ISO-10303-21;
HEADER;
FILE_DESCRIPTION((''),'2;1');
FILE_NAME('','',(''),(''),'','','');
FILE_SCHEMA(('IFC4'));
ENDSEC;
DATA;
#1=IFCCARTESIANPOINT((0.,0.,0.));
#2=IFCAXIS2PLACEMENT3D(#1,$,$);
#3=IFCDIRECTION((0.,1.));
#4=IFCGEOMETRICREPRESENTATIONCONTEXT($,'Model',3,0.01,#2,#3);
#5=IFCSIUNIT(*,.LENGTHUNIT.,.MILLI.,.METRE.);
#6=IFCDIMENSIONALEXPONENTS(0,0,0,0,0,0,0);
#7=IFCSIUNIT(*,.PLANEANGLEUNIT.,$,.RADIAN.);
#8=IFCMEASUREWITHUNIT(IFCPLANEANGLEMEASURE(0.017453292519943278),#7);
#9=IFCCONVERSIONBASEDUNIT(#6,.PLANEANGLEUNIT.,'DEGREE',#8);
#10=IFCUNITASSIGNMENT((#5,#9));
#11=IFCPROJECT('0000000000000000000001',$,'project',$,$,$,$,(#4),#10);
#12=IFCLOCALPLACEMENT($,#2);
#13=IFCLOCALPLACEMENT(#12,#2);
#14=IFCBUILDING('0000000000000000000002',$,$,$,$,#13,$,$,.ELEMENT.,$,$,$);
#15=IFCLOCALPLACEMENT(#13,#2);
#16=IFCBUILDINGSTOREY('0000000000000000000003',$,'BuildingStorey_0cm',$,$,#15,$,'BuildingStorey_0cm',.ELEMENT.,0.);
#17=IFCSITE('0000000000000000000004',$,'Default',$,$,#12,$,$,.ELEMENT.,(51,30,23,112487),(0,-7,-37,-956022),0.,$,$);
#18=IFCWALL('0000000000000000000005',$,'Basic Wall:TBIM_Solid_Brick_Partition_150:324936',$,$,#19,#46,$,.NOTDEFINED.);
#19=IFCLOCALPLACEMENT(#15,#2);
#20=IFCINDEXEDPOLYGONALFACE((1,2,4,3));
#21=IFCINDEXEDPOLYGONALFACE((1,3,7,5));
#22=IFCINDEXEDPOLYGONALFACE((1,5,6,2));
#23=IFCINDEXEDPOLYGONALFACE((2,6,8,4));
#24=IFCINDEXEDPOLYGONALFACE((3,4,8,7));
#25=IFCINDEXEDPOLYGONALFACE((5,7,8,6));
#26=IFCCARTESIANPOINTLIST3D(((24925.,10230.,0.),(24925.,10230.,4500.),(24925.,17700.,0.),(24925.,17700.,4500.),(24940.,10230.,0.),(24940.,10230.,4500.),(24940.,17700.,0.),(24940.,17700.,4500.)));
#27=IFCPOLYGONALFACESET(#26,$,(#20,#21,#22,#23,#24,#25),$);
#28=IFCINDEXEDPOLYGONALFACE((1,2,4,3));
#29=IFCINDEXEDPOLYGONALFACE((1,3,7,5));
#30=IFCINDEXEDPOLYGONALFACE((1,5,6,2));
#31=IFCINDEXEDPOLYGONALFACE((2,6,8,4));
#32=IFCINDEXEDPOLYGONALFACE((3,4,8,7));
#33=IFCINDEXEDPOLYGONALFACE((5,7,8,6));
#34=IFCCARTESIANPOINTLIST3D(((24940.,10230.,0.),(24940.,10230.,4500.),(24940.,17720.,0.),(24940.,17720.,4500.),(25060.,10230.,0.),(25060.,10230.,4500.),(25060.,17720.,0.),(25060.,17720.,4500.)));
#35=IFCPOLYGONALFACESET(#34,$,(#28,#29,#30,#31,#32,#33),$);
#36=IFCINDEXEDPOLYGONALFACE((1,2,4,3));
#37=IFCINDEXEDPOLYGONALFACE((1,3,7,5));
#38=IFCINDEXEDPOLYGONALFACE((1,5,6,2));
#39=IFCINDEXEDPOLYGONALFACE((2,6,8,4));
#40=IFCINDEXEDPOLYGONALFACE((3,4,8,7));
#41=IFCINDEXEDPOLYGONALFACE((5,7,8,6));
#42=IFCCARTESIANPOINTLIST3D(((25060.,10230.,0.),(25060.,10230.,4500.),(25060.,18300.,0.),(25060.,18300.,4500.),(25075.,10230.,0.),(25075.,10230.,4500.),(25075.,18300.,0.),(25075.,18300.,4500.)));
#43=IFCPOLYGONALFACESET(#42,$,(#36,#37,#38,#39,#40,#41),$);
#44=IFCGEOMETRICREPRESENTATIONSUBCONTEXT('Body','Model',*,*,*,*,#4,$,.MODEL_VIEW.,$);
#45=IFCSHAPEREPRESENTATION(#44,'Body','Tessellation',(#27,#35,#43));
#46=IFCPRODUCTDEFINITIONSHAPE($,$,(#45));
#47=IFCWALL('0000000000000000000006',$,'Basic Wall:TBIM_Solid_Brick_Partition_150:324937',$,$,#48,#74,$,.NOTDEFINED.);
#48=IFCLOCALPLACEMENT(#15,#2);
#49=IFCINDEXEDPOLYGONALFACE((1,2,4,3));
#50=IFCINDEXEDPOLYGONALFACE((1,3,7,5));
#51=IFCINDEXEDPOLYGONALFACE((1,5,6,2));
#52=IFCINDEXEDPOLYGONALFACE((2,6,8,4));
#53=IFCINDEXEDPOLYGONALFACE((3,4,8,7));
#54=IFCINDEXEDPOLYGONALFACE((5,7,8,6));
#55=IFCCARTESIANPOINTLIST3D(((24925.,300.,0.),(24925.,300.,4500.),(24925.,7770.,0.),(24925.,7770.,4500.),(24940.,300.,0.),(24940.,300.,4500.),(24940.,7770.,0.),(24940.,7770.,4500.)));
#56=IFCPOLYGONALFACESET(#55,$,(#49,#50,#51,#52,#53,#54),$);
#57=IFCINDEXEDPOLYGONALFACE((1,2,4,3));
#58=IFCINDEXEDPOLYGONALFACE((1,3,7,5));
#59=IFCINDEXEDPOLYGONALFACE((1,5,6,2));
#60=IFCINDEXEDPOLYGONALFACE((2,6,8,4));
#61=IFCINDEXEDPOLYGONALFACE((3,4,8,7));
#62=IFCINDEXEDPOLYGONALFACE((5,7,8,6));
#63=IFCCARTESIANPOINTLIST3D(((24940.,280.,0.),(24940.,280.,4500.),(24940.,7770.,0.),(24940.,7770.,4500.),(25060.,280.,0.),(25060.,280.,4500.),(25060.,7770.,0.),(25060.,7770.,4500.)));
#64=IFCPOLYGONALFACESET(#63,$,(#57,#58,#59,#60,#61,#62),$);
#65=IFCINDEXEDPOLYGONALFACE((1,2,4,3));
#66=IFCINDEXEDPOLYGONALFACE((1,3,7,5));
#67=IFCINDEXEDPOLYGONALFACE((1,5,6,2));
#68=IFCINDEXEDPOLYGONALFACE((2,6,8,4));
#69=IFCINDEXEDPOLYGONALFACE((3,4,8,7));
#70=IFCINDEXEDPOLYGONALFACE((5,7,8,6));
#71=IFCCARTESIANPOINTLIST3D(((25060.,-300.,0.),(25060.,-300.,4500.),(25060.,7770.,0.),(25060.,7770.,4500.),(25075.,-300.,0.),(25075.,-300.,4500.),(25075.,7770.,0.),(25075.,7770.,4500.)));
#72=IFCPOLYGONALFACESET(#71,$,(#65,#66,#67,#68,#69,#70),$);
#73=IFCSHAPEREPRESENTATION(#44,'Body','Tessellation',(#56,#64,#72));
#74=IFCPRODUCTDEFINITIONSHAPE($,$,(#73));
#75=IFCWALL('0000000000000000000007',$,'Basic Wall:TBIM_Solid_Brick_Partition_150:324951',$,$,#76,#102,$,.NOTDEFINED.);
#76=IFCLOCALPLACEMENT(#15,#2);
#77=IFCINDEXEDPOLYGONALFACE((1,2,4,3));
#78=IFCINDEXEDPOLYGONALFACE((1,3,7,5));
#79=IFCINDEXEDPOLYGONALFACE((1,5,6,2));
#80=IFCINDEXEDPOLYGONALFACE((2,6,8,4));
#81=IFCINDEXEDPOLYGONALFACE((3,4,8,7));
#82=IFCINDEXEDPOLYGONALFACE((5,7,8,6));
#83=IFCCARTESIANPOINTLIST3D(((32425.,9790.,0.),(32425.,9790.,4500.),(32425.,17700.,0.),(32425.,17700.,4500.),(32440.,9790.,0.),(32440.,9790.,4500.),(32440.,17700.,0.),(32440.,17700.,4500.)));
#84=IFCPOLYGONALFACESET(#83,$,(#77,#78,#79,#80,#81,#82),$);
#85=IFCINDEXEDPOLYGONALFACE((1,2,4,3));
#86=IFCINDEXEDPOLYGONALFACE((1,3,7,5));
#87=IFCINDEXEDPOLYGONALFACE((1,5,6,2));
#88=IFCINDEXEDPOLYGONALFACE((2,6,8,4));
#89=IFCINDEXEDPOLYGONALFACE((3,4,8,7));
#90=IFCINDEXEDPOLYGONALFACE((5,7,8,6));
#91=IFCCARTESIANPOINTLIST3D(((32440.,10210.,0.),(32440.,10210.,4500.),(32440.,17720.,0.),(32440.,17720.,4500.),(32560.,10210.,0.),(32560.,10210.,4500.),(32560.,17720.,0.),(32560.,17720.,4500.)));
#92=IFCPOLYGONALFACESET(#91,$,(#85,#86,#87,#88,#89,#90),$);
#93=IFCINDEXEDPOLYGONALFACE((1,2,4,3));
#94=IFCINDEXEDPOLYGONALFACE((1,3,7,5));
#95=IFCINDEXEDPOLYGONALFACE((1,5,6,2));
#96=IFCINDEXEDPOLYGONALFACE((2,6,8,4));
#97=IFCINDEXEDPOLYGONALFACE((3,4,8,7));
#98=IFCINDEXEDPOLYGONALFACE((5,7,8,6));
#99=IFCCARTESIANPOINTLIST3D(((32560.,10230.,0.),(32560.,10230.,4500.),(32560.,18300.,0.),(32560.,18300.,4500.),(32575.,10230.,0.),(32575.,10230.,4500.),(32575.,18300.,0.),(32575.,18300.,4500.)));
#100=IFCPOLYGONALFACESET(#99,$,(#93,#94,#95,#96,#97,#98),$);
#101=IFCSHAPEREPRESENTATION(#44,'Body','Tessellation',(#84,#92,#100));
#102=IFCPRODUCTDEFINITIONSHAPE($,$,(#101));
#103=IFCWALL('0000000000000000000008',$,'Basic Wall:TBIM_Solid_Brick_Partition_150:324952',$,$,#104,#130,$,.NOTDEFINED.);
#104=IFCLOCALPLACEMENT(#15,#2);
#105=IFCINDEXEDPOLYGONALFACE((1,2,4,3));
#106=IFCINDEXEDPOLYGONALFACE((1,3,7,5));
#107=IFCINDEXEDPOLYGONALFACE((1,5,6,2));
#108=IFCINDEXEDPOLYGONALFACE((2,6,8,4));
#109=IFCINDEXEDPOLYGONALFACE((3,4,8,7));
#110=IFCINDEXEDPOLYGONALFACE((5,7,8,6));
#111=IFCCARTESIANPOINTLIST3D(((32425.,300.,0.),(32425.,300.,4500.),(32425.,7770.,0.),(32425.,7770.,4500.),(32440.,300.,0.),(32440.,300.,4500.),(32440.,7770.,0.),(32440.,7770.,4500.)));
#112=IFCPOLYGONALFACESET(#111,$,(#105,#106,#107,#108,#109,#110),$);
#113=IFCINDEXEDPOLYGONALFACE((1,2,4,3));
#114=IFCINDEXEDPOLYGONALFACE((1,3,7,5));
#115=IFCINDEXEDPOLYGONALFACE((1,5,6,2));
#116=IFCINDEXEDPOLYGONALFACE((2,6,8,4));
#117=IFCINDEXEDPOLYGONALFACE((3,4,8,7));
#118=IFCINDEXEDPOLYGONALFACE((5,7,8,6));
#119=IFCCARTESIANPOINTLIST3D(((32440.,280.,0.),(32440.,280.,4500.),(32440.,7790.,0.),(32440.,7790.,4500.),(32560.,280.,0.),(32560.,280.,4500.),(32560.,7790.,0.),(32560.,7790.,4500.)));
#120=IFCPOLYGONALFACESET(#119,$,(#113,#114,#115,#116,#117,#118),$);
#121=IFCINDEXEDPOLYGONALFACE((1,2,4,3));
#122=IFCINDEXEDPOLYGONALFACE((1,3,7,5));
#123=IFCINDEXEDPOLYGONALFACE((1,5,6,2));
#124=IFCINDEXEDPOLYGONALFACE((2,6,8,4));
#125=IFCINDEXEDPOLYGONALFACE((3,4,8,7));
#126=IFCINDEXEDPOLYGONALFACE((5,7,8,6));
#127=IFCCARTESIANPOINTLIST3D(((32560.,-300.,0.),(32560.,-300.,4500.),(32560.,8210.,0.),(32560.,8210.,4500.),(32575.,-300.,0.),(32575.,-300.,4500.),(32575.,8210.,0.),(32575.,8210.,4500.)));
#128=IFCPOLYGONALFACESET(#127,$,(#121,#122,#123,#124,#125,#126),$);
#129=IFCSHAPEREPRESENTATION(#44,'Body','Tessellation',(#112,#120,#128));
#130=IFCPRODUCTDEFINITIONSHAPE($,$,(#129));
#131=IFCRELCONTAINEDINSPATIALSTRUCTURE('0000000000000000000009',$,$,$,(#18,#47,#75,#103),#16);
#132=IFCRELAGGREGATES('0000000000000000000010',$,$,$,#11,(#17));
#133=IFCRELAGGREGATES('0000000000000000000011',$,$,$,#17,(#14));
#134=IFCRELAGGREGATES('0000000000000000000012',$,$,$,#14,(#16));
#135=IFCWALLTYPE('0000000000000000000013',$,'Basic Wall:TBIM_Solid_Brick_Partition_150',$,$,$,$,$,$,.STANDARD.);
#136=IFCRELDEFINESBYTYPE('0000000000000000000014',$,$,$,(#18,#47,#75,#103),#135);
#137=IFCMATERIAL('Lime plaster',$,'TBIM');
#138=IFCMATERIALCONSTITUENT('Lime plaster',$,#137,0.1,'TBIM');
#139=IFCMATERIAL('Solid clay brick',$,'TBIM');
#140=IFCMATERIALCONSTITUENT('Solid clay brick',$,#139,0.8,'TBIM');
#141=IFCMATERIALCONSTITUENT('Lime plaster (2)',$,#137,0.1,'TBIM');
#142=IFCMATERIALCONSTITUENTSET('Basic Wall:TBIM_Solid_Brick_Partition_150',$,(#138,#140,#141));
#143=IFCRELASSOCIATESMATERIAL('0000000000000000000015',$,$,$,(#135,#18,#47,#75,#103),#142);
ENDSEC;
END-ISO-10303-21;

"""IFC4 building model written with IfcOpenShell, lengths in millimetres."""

from ifc_helpers import new_model, entity, si_unit, converted_unit, direction, frame, origin, place, context, subcontext, project, spatial, indexed_curve, outline, extrude, material, constituent, constituent_set, type_object, element, save


model = new_model("IFC4")

# Units and contexts
model_context = context("Model", 3, precision=0.01, world=origin(), true_north=direction((0.0, 1.0)))
body_context = subcontext(model_context, "Body", "Model", "MODEL_VIEW")
ifc_project = project(units=[si_unit("LENGTHUNIT", "METRE", prefix="MILLI"), converted_unit("PLANEANGLEUNIT", "DEGREE", entity("IfcPlaneAngleMeasure", 0.017453292519943278), si_unit("PLANEANGLEUNIT", "RADIAN"), dimensions=[0, 0, 0, 0, 0, 0, 0])], contexts=[model_context])

# Site, building, storey
site_placement = place(None, origin())
site = spatial("IfcSite", under=ifc_project, at=site_placement, Name="Default", CompositionType="ELEMENT", RefLatitude=(51, 30, 23, 112487), RefLongitude=(0, -7, -37, -956022), RefElevation=0.0)
building_placement = place(site_placement, origin())
building = spatial("IfcBuilding", under=site, at=building_placement, CompositionType="ELEMENT")
storey_placement = place(building_placement, origin())
storey = spatial("IfcBuildingStorey", under=building, at=storey_placement, Name="BuildingStorey_0cm", LongName="BuildingStorey_0cm", CompositionType="ELEMENT", Elevation=0.0)

# Shared definitions
ifc_material_1 = material(Name="Solid clay brick", Category="TBIM")
ifc_material_2 = material(Name="Lime plaster", Category="TBIM")

# Walls
ifc_constituent_1 = constituent(ifc_material_2, Name="Lime plaster", Category="TBIM", fraction=0.1)
ifc_constituent_2 = constituent(ifc_material_1, Name="Solid clay brick", Category="TBIM", fraction=0.8)
ifc_constituent_3 = constituent(ifc_material_2, Name="Lime plaster (2)", Category="TBIM", fraction=0.1)
ifc_constituent_set_1 = constituent_set(constituents=[ifc_constituent_1, ifc_constituent_2, ifc_constituent_3], Name="Basic Wall:TBIM_Solid_Brick_Partition_150")
wall_type_1 = type_object("IfcWallType", Name="Basic Wall:TBIM_Solid_Brick_Partition_150", PredefinedType="STANDARD", material=ifc_constituent_set_1)
wall_1_placement = place(storey_placement, frame((25000.0, 10230.0, 0.0), z_axis=(0.0, 0.0, 1.0), x_axis=(0.0, 1.0, 0.0)))
element("IfcWall", 1, at=wall_1_placement, inside=storey, type_object=wall_type_1, material=ifc_constituent_set_1, Name="Basic Wall:TBIM_Solid_Brick_Partition_150:324936", PredefinedType="NOTDEFINED", context=body_context, shape_type="SweptSolid", body=[
    extrude(outline(indexed_curve([(-7.5, -3735.0), (7.5, -3735.0), (7.5, 3735.0), (-7.5, 3735.0), (-7.5, -3735.0)], self_intersect=False)), frame((3735.0, 67.5, 0.0), z_axis=(0.0, 0.0, 1.0), x_axis=(0.0, -1.0, 0.0)), (0.0, 0.0, 1.0), 4500.0),
    extrude(outline(indexed_curve([(-3745.0, -60.0), (3745.0, -60.0), (3745.0, 60.0), (-3745.0, 60.0), (-3745.0, -60.0)], self_intersect=False)), frame((3745.0, 0.0, 0.0)), (0.0, 0.0, 1.0), 4500.0),
    extrude(outline(indexed_curve([(-7.5, -4035.0), (7.5, -4035.0), (7.5, 4035.0), (-7.5, 4035.0), (-7.5, -4035.0)], self_intersect=False)), frame((4035.0, -67.5, 0.0), z_axis=(0.0, 0.0, 1.0), x_axis=(0.0, 1.0, 0.0)), (0.0, 0.0, 1.0), 4500.0),
])
wall_2_placement = place(storey_placement, frame((25000.0, 300.0, 0.0), z_axis=(0.0, 0.0, 1.0), x_axis=(0.0, 1.0, 0.0)))
element("IfcWall", 2, at=wall_2_placement, inside=storey, type_object=wall_type_1, material=ifc_constituent_set_1, Name="Basic Wall:TBIM_Solid_Brick_Partition_150:324937", PredefinedType="NOTDEFINED", context=body_context, shape_type="SweptSolid", body=[
    extrude(outline(indexed_curve([(-7.5, -3735.0), (7.5, -3735.0), (7.5, 3735.0), (-7.5, 3735.0), (-7.5, -3735.0)], self_intersect=False)), frame((3735.0, 67.5, 0.0), z_axis=(0.0, 0.0, 1.0), x_axis=(0.0, -1.0, 0.0)), (0.0, 0.0, 1.0), 4500.0),
    extrude(outline(indexed_curve([(-3745.0, -60.0), (3745.0, -60.0), (3745.0, 60.0), (-3745.0, 60.0), (-3745.0, -60.0)], self_intersect=False)), frame((3725.0, 0.0, 0.0)), (0.0, 0.0, 1.0), 4500.0),
    extrude(outline(indexed_curve([(-7.5, -4035.0), (7.5, -4035.0), (7.5, 4035.0), (-7.5, 4035.0), (-7.5, -4035.0)], self_intersect=False)), frame((3435.0, -67.5, 0.0), z_axis=(0.0, 0.0, 1.0), x_axis=(0.0, 1.0, 0.0)), (0.0, 0.0, 1.0), 4500.0),
])
wall_3_placement = place(storey_placement, frame((32500.0, 10230.0, 0.0), z_axis=(0.0, 0.0, 1.0), x_axis=(0.0, 1.0, 0.0)))
element("IfcWall", 3, at=wall_3_placement, inside=storey, type_object=wall_type_1, material=ifc_constituent_set_1, Name="Basic Wall:TBIM_Solid_Brick_Partition_150:324951", PredefinedType="NOTDEFINED", context=body_context, shape_type="SweptSolid", body=[
    extrude(outline(indexed_curve([(-7.5, -3955.0), (7.5, -3955.0), (7.5, 3955.0), (-7.5, 3955.0), (-7.5, -3955.0)], self_intersect=False)), frame((3515.0, 67.5, 0.0), z_axis=(0.0, 0.0, 1.0), x_axis=(0.0, -1.0, 0.0)), (0.0, 0.0, 1.0), 4500.0),
    extrude(outline(indexed_curve([(-3755.0, -60.0), (3755.0, -60.0), (3755.0, 60.0), (-3755.0, 60.0), (-3755.0, -60.0)], self_intersect=False)), frame((3735.0, 0.0, 0.0)), (0.0, 0.0, 1.0), 4500.0),
    extrude(outline(indexed_curve([(-7.5, -4035.0), (7.5, -4035.0), (7.5, 4035.0), (-7.5, 4035.0), (-7.5, -4035.0)], self_intersect=False)), frame((4035.0, -67.5, 0.0), z_axis=(0.0, 0.0, 1.0), x_axis=(0.0, 1.0, 0.0)), (0.0, 0.0, 1.0), 4500.0),
])
wall_4_placement = place(storey_placement, frame((32500.0, 300.0, 0.0), z_axis=(0.0, 0.0, 1.0), x_axis=(0.0, 1.0, 0.0)))
element("IfcWall", 4, at=wall_4_placement, inside=storey, type_object=wall_type_1, material=ifc_constituent_set_1, Name="Basic Wall:TBIM_Solid_Brick_Partition_150:324952", PredefinedType="NOTDEFINED", context=body_context, shape_type="SweptSolid", body=[
    extrude(outline(indexed_curve([(-7.5, -3735.0), (7.5, -3735.0), (7.5, 3735.0), (-7.5, 3735.0), (-7.5, -3735.0)], self_intersect=False)), frame((3735.0, 67.5, 0.0), z_axis=(0.0, 0.0, 1.0), x_axis=(0.0, -1.0, 0.0)), (0.0, 0.0, 1.0), 4500.0),
    extrude(outline(indexed_curve([(-3755.0, -60.0), (3755.0, -60.0), (3755.0, 60.0), (-3755.0, 60.0), (-3755.0, -60.0)], self_intersect=False)), frame((3735.0, 0.0, 0.0)), (0.0, 0.0, 1.0), 4500.0),
    extrude(outline(indexed_curve([(-7.5, -4255.0), (7.5, -4255.0), (7.5, 4255.0), (-7.5, 4255.0), (-7.5, -4255.0)], self_intersect=False)), frame((3655.0, -67.5, 0.0), z_axis=(0.0, 0.0, 1.0), x_axis=(0.0, 1.0, 0.0)), (0.0, 0.0, 1.0), 4500.0),
])

save(model, "model.ifc")
